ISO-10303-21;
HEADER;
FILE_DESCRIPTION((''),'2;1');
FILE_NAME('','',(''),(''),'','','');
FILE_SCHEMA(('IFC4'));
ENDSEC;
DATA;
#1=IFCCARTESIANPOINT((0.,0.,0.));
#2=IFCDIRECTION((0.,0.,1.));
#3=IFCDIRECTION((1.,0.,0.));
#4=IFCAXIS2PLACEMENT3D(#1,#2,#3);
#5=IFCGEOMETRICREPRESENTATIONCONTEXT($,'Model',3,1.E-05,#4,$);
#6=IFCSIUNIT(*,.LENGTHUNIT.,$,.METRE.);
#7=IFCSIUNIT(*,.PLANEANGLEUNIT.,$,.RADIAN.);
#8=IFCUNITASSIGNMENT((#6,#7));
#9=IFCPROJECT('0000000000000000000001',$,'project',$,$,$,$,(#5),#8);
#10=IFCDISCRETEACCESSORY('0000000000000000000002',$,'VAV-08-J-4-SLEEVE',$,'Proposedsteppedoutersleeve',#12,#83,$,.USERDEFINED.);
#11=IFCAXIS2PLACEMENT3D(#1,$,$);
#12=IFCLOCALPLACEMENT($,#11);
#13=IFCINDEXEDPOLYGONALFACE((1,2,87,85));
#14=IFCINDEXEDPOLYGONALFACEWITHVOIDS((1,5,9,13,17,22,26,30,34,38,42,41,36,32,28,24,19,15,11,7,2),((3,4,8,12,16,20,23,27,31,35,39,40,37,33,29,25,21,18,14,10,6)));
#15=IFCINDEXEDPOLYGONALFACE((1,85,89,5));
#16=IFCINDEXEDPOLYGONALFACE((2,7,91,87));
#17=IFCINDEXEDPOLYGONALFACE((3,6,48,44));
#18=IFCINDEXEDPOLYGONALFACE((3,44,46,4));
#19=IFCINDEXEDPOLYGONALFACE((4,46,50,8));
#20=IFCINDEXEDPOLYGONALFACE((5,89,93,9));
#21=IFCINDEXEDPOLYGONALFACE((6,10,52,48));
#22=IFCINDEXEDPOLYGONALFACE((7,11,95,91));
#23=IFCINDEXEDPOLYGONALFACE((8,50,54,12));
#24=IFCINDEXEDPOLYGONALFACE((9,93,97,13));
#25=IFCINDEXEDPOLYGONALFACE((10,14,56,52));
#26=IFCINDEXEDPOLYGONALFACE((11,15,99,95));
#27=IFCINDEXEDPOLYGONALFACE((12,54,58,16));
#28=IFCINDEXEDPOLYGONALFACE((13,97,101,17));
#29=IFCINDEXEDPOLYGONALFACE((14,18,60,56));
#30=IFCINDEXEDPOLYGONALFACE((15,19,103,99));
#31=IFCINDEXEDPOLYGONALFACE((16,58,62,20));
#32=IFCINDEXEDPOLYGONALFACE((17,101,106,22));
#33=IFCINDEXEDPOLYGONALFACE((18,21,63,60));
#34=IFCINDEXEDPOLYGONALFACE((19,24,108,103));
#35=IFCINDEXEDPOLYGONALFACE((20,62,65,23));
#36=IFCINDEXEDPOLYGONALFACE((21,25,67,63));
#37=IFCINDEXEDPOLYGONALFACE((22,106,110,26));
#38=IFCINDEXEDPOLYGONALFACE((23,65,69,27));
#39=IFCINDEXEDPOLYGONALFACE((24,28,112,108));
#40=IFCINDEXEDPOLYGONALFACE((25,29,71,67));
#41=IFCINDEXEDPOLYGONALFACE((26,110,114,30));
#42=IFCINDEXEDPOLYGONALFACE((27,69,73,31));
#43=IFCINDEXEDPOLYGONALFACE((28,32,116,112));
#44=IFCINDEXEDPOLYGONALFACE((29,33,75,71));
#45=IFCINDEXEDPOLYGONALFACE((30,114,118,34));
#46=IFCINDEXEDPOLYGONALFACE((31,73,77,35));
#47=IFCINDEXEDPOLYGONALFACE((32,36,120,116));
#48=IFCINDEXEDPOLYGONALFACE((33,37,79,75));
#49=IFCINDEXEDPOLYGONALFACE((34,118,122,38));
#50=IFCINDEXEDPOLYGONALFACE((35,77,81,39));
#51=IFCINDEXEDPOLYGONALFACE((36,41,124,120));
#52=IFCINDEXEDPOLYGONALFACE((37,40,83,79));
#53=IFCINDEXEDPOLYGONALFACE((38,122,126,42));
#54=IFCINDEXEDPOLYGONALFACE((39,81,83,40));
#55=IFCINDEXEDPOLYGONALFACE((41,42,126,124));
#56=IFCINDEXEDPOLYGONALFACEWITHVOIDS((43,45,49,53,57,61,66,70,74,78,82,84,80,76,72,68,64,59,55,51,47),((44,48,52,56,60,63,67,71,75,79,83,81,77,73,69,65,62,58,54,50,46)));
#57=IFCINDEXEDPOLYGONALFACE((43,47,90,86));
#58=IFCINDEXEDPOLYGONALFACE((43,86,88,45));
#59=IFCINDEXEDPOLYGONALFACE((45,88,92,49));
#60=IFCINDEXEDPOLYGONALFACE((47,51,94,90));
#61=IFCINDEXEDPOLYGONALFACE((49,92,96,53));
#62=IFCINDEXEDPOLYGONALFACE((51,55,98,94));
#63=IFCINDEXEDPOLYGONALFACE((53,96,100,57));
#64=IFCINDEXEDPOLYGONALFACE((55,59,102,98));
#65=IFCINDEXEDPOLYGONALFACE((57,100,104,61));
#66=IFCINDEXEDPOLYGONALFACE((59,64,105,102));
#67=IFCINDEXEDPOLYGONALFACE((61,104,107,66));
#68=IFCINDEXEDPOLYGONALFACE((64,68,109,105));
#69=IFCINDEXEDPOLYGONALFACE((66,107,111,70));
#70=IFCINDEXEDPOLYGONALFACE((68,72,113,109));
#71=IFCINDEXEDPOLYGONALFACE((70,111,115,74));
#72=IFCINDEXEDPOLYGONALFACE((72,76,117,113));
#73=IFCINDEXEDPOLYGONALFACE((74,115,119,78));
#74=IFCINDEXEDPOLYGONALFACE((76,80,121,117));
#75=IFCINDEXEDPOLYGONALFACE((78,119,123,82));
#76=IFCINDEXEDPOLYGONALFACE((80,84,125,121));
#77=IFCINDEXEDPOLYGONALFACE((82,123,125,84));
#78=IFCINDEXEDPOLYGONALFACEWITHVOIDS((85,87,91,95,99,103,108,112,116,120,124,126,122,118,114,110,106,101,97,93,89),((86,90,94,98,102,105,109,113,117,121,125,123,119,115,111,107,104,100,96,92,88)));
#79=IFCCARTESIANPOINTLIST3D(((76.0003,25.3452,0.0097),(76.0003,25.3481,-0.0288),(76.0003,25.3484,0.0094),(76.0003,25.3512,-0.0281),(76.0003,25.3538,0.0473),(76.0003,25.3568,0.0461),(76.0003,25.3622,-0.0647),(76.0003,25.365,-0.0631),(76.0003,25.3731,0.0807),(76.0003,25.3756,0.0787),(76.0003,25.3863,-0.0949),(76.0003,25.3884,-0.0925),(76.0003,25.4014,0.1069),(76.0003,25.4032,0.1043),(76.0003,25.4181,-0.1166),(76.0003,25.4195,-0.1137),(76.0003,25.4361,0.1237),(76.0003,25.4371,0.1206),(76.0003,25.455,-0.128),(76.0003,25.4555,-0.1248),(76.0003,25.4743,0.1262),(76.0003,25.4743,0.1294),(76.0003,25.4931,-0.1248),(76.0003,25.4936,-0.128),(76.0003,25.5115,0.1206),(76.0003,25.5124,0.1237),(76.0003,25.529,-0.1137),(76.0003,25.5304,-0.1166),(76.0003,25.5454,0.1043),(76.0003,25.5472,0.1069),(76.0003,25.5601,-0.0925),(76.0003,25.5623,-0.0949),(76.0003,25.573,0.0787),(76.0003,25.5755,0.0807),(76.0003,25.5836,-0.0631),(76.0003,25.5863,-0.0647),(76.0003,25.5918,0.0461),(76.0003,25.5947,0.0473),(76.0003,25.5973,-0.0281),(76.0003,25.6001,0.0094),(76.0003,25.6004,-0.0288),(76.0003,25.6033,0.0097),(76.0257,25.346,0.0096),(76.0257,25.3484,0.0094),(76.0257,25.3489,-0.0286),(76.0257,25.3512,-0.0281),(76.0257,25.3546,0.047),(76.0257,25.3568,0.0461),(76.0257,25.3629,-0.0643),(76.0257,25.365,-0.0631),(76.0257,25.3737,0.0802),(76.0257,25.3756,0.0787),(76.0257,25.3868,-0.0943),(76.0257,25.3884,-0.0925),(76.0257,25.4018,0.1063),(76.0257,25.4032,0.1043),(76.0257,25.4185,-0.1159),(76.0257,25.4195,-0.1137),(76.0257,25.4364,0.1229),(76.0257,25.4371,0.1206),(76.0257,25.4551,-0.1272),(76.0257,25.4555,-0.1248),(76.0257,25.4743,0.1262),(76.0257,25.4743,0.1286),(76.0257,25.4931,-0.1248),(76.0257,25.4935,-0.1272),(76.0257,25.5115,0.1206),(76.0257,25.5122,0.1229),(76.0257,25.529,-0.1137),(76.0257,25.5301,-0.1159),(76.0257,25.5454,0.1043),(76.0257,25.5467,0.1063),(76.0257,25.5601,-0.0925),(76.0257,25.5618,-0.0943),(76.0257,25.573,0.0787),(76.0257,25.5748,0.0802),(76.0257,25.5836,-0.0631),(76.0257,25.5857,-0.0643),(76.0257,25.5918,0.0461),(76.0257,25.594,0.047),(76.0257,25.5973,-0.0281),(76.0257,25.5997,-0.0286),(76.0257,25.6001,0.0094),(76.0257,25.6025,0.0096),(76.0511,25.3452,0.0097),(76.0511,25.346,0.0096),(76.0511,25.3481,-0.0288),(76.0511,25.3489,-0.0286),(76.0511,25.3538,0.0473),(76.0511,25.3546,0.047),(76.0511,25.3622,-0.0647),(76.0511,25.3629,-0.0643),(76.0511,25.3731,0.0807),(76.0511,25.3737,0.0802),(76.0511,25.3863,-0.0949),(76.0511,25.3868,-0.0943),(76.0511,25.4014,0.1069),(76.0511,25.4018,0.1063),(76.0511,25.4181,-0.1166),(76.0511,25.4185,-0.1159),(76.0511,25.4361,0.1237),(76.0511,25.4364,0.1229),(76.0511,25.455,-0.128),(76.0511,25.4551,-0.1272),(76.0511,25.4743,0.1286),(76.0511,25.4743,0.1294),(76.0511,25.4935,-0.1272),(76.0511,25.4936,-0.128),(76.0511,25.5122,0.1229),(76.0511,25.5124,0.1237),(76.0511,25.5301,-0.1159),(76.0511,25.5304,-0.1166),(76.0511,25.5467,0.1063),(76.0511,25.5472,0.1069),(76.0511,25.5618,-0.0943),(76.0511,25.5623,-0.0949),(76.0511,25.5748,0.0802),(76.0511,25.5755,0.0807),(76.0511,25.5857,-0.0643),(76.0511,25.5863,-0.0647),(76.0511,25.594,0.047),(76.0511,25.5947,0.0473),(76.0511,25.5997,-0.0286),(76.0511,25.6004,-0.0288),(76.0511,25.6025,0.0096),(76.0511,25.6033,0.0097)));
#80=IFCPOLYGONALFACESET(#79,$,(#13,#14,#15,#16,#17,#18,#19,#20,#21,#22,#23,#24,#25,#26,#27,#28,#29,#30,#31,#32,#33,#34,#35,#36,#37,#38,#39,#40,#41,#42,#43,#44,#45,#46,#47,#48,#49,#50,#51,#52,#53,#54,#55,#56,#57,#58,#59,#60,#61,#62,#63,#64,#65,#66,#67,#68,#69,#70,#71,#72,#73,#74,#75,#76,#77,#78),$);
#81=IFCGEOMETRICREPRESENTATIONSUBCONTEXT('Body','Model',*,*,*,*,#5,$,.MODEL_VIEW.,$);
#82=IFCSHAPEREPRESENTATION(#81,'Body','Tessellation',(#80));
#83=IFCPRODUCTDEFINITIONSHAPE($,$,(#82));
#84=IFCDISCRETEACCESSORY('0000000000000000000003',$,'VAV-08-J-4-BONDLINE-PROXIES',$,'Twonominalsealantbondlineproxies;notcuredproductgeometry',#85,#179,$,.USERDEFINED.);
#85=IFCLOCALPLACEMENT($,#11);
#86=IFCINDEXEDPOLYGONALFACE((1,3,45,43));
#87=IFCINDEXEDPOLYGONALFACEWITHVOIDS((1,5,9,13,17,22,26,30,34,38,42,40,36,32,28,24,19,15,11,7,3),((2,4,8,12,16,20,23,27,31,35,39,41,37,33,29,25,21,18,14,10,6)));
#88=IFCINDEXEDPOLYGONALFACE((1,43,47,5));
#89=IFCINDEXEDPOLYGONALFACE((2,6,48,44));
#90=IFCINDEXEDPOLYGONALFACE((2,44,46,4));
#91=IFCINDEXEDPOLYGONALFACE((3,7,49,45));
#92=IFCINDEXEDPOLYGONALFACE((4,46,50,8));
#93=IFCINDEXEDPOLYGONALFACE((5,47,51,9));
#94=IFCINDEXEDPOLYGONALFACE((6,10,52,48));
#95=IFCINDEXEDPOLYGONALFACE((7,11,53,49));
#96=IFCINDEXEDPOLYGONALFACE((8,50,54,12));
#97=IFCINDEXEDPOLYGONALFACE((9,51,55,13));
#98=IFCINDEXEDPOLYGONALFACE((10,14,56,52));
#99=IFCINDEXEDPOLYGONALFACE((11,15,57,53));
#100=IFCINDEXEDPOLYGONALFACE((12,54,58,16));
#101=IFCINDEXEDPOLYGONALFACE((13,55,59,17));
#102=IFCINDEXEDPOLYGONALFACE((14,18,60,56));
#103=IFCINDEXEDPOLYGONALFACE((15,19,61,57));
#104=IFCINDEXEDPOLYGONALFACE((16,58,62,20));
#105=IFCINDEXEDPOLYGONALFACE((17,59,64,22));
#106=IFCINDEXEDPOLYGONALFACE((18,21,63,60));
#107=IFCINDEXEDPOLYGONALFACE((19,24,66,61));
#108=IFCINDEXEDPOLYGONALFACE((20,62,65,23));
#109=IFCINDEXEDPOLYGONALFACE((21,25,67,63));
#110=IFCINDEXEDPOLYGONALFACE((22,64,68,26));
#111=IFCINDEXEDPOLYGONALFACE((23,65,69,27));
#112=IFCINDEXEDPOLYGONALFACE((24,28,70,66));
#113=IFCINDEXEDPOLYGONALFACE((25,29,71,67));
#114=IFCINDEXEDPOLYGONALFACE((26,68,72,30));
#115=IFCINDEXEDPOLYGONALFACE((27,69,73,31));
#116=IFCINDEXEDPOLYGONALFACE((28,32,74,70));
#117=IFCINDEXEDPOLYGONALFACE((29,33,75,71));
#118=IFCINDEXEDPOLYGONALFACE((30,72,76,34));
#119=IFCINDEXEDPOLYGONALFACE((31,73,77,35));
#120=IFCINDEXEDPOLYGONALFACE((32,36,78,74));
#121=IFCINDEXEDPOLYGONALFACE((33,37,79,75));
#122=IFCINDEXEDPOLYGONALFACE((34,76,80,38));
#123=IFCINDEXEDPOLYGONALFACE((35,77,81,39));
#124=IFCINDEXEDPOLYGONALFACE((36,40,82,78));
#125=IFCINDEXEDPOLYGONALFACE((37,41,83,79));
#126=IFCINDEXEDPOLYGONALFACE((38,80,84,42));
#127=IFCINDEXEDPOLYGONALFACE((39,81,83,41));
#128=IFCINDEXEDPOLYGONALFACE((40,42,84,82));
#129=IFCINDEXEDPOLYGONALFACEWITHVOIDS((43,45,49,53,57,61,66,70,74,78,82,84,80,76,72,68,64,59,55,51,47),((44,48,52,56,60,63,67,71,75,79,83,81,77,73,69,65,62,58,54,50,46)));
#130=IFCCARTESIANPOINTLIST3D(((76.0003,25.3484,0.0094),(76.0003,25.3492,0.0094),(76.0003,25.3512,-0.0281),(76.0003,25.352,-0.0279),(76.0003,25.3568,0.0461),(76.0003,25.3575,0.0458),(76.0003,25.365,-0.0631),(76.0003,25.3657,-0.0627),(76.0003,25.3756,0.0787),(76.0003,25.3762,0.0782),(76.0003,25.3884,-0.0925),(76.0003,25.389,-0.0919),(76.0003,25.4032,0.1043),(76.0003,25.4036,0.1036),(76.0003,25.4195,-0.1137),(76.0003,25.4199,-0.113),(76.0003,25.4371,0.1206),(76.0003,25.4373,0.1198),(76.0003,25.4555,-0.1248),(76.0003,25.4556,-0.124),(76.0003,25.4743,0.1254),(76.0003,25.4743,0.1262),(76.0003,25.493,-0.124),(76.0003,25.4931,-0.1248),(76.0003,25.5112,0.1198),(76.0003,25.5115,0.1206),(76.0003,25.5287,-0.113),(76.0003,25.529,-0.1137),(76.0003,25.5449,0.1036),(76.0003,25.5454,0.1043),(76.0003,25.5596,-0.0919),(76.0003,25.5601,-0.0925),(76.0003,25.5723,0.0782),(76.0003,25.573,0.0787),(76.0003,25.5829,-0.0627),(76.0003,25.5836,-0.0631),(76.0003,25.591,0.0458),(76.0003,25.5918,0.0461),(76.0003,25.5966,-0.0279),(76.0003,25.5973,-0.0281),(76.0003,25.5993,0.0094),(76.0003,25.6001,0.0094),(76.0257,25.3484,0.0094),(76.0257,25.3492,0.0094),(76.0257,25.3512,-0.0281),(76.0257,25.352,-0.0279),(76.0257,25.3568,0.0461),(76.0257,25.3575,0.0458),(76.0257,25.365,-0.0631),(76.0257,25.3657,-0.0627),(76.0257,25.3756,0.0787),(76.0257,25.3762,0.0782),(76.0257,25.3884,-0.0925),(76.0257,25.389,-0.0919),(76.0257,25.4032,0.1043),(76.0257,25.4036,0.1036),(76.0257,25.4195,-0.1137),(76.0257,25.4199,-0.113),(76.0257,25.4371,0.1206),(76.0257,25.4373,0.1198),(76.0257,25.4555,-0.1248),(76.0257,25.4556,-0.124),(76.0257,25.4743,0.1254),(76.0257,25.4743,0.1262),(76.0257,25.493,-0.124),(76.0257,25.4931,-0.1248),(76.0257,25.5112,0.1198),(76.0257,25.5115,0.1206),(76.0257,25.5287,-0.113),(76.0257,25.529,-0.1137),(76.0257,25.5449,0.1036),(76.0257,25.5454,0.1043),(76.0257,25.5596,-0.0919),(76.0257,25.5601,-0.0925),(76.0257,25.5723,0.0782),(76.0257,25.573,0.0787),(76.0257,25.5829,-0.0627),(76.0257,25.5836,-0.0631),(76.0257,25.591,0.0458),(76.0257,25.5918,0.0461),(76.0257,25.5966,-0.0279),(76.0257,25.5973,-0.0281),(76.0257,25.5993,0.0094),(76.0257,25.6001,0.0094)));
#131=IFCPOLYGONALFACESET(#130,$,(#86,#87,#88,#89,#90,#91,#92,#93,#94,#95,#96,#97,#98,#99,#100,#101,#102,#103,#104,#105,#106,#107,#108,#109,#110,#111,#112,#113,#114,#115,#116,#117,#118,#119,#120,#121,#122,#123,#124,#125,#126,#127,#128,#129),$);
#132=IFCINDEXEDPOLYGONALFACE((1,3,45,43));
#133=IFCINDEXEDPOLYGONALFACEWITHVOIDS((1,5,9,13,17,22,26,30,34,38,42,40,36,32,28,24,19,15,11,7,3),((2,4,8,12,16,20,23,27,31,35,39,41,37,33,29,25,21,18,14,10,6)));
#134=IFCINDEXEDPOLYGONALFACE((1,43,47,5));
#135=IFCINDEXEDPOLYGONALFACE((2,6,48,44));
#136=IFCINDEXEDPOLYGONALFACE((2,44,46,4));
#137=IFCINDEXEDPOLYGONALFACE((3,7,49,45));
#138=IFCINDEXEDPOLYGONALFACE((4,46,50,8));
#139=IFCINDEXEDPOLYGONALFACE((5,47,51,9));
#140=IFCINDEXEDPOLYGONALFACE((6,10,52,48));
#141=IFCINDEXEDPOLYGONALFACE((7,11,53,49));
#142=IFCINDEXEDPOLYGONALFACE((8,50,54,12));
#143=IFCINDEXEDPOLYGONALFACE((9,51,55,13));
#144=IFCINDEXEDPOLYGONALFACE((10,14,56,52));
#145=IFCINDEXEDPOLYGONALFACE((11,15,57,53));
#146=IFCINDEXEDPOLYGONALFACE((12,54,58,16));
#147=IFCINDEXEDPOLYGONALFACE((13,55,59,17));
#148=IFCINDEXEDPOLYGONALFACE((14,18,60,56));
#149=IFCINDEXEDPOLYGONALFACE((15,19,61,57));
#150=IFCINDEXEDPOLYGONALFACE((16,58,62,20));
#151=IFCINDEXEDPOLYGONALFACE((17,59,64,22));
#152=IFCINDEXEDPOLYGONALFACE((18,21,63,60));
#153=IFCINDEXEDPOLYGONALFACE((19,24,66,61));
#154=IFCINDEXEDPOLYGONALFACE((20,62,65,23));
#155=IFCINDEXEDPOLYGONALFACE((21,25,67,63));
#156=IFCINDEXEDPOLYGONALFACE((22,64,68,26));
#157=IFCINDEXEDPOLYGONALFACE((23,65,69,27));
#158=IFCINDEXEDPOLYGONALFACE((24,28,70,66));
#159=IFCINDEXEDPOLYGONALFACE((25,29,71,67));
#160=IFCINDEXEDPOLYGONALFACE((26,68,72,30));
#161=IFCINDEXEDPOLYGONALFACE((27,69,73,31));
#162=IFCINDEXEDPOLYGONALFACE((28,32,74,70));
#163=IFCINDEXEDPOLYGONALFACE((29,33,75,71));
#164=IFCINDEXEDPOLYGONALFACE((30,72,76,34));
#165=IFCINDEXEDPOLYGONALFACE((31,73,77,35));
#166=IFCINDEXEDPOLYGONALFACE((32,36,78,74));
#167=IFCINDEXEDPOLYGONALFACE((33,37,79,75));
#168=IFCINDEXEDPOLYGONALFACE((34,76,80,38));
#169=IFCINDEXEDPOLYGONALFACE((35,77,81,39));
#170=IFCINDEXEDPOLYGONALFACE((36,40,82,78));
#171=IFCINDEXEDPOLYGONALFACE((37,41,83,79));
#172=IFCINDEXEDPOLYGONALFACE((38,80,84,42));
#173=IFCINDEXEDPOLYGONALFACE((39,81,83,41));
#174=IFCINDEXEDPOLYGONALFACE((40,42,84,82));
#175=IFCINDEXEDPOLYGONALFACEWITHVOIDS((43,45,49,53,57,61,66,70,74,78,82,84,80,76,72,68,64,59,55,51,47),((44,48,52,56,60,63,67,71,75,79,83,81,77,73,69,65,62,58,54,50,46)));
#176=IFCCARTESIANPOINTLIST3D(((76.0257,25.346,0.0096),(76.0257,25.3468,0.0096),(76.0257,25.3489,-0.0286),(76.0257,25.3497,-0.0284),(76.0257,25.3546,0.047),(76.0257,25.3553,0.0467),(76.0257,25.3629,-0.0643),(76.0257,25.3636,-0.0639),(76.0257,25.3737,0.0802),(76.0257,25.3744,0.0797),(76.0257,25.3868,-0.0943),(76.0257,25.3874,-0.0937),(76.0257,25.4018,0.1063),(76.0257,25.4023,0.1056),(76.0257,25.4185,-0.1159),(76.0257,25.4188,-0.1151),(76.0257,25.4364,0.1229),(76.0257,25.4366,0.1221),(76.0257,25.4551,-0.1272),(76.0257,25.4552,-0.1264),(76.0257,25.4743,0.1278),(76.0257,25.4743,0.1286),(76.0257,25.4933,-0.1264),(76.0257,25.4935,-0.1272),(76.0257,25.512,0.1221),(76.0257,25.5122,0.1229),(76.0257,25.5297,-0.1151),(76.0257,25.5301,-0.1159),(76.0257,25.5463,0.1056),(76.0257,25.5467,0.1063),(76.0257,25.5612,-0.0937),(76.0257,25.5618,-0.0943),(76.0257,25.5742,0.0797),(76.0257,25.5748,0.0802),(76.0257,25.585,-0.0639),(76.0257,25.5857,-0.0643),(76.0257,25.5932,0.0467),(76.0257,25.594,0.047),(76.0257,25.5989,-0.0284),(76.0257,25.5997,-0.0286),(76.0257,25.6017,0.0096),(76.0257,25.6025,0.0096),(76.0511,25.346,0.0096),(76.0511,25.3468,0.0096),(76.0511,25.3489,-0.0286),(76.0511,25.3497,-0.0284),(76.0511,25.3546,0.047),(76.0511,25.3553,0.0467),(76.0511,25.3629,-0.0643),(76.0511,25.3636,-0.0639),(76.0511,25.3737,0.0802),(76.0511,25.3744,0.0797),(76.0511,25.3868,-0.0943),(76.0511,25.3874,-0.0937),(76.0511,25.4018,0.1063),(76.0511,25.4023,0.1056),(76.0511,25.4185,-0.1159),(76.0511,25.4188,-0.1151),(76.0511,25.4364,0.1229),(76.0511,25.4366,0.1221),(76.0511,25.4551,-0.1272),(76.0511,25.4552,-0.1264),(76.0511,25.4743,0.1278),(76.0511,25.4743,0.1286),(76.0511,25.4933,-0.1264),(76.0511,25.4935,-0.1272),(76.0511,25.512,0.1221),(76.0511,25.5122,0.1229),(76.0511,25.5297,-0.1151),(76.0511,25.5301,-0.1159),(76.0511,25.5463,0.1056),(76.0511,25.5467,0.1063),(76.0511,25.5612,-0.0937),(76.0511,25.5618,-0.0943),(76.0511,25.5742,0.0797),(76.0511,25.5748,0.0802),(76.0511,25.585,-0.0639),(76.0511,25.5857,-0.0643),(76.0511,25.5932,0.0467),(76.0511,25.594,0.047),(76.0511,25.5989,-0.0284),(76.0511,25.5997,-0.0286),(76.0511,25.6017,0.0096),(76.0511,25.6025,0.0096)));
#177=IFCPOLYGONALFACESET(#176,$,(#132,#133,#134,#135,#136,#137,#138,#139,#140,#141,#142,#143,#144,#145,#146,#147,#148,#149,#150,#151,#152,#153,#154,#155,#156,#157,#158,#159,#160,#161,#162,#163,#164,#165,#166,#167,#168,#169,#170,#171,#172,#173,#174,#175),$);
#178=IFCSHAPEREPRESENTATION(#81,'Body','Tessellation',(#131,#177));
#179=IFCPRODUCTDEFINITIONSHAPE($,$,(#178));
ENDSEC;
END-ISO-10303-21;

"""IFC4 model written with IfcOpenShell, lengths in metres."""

from ifc_helpers import new_model, entity, si_unit, frame, origin_with_axes, place, context, subcontext, project, element, save


model = new_model("IFC4")

# Units and contexts
model_context = context("Model", 3, precision=1e-05, world=origin_with_axes())
body_context = subcontext(model_context, "Body", "Model", "MODEL_VIEW")
ifc_project = project(units=[si_unit("LENGTHUNIT", "METRE"), si_unit("PLANEANGLEUNIT", "RADIAN")], contexts=[model_context])

# Discrete accessories
discrete_accessory_1_placement = place(None, frame((76.0257, 25.4743, 0.0), z_axis=(0.0, 1.0, 0.0), x_axis=(0.0, 0.0, 1.0)))
element("IfcDiscreteAccessory", 1, at=discrete_accessory_1_placement, Name="VAV-08-J-4-SLEEVE", ObjectType="Proposedsteppedoutersleeve", PredefinedType="USERDEFINED", context=body_context, shape_type="SweptSolid", body=[
    entity("IfcRevolvedAreaSolid", entity("IfcArbitraryClosedProfileDef", "AREA", None, entity("IfcPolyline", [entity("IfcCartesianPoint", [0.1262, -0.0254]), entity("IfcCartesianPoint", [0.1294, -0.0254]), entity("IfcCartesianPoint", [0.1294, 0.0254]), entity("IfcCartesianPoint", [0.1286, 0.0254]), entity("IfcCartesianPoint", [0.1286, 0.0]), entity("IfcCartesianPoint", [0.1262, 0.0]), entity("IfcCartesianPoint", [0.1262, -0.0254])])), entity("IfcAxis2Placement3D", entity("IfcCartesianPoint", [0.0, 0.0, 0.0])), entity("IfcAxis1Placement", entity("IfcCartesianPoint", [0.0, 0.0, 0.0]), entity("IfcDirection", [0.0, 1.0, 0.0])), 6.283185),
])
discrete_accessory_2_placement = place(None, frame((76.0257, 25.4743, 0.0), z_axis=(0.0, 1.0, 0.0), x_axis=(0.0, 0.0, 1.0)))
element("IfcDiscreteAccessory", 2, at=discrete_accessory_2_placement, Name="VAV-08-J-4-BONDLINE-PROXIES", ObjectType="Twonominalsealantbondlineproxies;notcuredproductgeometry", PredefinedType="USERDEFINED", context=body_context, shape_type="SweptSolid", body=[
    entity("IfcRevolvedAreaSolid", entity("IfcArbitraryClosedProfileDef", "AREA", None, entity("IfcPolyline", [entity("IfcCartesianPoint", [0.1254, -0.0254]), entity("IfcCartesianPoint", [0.1262, -0.0254]), entity("IfcCartesianPoint", [0.1262, 0.0]), entity("IfcCartesianPoint", [0.1254, 0.0]), entity("IfcCartesianPoint", [0.1254, -0.0254])])), entity("IfcAxis2Placement3D", entity("IfcCartesianPoint", [0.0, 0.0, 0.0])), entity("IfcAxis1Placement", entity("IfcCartesianPoint", [0.0, 0.0, 0.0]), entity("IfcDirection", [0.0, 1.0, 0.0])), 6.283185),
    entity("IfcRevolvedAreaSolid", entity("IfcArbitraryClosedProfileDef", "AREA", None, entity("IfcPolyline", [entity("IfcCartesianPoint", [0.1278, 0.0]), entity("IfcCartesianPoint", [0.1286, 0.0]), entity("IfcCartesianPoint", [0.1286, 0.0254]), entity("IfcCartesianPoint", [0.1278, 0.0254]), entity("IfcCartesianPoint", [0.1278, 0.0])])), entity("IfcAxis2Placement3D", entity("IfcCartesianPoint", [0.0, 0.0, 0.0])), entity("IfcAxis1Placement", entity("IfcCartesianPoint", [0.0, 0.0, 0.0]), entity("IfcDirection", [0.0, 1.0, 0.0])), 6.283185),
])

save(model, "model.ifc")
